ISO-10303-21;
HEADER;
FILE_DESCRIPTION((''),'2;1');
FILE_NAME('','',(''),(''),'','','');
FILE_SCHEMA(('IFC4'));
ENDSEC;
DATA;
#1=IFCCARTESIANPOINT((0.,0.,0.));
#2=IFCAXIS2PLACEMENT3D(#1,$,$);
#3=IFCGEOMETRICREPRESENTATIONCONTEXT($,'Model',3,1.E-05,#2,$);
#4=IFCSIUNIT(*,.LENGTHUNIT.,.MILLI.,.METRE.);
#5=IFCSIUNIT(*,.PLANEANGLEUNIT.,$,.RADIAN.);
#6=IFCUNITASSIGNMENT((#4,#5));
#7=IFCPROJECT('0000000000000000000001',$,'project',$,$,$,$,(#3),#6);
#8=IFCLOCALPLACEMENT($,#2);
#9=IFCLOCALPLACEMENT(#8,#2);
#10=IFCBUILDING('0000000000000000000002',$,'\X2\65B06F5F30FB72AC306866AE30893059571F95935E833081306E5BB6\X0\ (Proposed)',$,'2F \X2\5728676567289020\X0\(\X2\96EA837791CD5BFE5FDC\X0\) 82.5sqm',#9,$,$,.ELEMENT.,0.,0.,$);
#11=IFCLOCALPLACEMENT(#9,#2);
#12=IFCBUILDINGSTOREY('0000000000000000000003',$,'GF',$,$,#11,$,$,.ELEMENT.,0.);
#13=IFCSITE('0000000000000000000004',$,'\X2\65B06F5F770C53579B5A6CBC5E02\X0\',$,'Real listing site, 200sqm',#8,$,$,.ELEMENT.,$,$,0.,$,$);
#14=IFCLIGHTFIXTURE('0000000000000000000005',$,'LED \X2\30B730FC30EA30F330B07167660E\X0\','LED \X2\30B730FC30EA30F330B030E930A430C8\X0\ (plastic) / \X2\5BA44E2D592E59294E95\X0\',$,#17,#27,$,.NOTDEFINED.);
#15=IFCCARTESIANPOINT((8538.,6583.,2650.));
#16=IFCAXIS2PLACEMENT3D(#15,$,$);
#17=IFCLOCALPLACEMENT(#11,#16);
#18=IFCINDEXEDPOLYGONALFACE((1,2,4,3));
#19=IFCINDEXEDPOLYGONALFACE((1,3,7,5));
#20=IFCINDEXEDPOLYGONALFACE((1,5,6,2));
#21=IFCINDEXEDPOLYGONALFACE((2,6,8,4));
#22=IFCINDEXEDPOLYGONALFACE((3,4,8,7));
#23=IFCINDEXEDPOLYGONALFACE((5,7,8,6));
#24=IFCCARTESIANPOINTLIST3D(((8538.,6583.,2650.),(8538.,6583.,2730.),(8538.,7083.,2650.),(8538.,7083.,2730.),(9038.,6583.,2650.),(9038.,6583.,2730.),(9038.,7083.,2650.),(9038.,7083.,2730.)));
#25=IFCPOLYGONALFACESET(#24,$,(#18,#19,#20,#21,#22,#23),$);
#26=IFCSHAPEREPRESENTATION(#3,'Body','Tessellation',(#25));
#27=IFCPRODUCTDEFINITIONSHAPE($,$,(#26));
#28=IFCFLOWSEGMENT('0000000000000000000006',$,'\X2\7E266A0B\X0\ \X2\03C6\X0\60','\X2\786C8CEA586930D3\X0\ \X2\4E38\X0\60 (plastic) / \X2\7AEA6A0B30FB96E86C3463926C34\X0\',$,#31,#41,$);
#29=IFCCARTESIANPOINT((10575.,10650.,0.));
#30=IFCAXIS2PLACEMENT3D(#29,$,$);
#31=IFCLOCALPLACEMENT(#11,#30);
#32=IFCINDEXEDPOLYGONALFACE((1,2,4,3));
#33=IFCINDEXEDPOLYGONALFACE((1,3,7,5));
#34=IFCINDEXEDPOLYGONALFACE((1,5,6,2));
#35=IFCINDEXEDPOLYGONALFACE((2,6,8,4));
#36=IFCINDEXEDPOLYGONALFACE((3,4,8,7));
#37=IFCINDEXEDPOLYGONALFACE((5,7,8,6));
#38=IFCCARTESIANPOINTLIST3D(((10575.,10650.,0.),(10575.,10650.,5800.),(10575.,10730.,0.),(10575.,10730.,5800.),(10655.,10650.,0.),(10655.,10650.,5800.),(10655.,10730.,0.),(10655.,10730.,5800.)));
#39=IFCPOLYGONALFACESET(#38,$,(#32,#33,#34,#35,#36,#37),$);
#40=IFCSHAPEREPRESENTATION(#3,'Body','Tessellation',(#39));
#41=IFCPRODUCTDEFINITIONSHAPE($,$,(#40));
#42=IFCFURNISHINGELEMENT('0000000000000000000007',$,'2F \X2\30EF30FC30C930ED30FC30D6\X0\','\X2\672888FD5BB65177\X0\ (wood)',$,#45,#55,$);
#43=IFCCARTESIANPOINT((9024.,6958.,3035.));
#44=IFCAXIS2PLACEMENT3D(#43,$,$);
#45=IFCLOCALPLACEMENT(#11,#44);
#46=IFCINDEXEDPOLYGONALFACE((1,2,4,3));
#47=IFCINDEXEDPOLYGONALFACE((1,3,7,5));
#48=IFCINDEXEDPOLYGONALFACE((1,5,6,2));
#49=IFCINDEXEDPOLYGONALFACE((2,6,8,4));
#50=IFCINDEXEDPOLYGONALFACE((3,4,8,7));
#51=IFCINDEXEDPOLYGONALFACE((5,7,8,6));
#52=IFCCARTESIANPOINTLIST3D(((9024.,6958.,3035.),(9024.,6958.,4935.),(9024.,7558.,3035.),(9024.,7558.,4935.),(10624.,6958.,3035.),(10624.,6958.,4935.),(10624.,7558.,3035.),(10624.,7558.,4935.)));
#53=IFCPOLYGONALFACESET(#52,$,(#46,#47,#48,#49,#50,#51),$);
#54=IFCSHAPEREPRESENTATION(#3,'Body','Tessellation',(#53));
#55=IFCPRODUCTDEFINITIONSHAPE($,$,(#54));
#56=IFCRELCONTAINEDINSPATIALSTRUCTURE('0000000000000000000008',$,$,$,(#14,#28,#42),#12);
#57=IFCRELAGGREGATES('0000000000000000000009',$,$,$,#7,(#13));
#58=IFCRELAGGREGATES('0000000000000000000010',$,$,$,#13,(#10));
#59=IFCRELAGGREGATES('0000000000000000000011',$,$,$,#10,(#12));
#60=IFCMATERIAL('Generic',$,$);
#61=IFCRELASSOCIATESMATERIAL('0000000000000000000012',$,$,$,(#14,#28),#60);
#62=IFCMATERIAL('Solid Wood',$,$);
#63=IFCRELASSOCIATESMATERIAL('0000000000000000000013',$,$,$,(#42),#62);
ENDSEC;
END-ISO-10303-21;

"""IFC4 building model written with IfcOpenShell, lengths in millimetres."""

from ifc_helpers import new_model, si_unit, frame, frame_2d, origin, place, context, project, spatial, rectangle, extrude, material, element, save


model = new_model("IFC4")

# Units and contexts
model_context = context("Model", 3, precision=1e-05, world=origin())
ifc_project = project(units=[si_unit("LENGTHUNIT", "METRE", prefix="MILLI"), si_unit("PLANEANGLEUNIT", "RADIAN")], contexts=[model_context])

# Site, building, storey
site_placement = place(None, origin())
site = spatial("IfcSite", under=ifc_project, at=site_placement, Name="新潟県南魚沼市", ObjectType="Real listing site, 200sqm", CompositionType="ELEMENT", RefElevation=0.0)
building_placement = place(site_placement, origin())
building = spatial("IfcBuilding", under=site, at=building_placement, Name="新潟・犬と暮らす土間広めの家 (Proposed)", ObjectType="2F 在来木造(雪荷重対応) 82.5sqm", CompositionType="ELEMENT", ElevationOfRefHeight=0.0, ElevationOfTerrain=0.0)
storey_placement = place(building_placement, origin())
storey = spatial("IfcBuildingStorey", under=building, at=storey_placement, Name="GF", CompositionType="ELEMENT", Elevation=0.0)

# Shared definitions
ifc_material_1 = material(Name="Solid Wood")

# Light fixture
ifc_material_2 = material(Name="Generic")
light_fixture_placement = place(storey_placement, frame((8538.0, 6583.0, 2650.0)))
element("IfcLightFixture", 1, at=light_fixture_placement, inside=storey, material=ifc_material_2, Name="LED シーリング照明", Description="LED シーリングライト (plastic) / 室中央天井", PredefinedType="NOTDEFINED", context=model_context, shape_type="SweptSolid", body=[
    extrude(rectangle(XDim=500.0, YDim=500.0, at=frame_2d((250.0, 250.0))), frame((8538.0, 6583.0, 2650.0)), (0.0, 0.0, 1.0), 80.0),
])

# Flow segment
flow_segment_placement = place(storey_placement, frame((10575.0, 10650.0, 0.0)))
element("IfcFlowSegment", 2, at=flow_segment_placement, inside=storey, material=ifc_material_2, Name="縦樋 φ60", Description="硬質塩ビ 丸60 (plastic) / 竪樋・雨水排水", context=model_context, shape_type="SweptSolid", body=[
    extrude(rectangle(XDim=80.0, YDim=80.0, at=frame_2d((40.0, 40.0))), frame((10575.0, 10650.0, 0.0)), (0.0, 0.0, 1.0), 5800.0),
])

# Furnishing element
furnishing_placement = place(storey_placement, frame((9024.0, 6958.0, 3035.0)))
element("IfcFurnishingElement", 3, at=furnishing_placement, inside=storey, material=ifc_material_1, Name="2F ワードローブ", Description="木製家具 (wood)", context=model_context, shape_type="SweptSolid", body=[
    extrude(rectangle(XDim=1600.0, YDim=600.0, at=frame_2d((800.0, 300.0))), frame((9024.0, 6958.0, 3035.0)), (0.0, 0.0, 1.0), 1900.0),
])

save(model, "model.ifc")
